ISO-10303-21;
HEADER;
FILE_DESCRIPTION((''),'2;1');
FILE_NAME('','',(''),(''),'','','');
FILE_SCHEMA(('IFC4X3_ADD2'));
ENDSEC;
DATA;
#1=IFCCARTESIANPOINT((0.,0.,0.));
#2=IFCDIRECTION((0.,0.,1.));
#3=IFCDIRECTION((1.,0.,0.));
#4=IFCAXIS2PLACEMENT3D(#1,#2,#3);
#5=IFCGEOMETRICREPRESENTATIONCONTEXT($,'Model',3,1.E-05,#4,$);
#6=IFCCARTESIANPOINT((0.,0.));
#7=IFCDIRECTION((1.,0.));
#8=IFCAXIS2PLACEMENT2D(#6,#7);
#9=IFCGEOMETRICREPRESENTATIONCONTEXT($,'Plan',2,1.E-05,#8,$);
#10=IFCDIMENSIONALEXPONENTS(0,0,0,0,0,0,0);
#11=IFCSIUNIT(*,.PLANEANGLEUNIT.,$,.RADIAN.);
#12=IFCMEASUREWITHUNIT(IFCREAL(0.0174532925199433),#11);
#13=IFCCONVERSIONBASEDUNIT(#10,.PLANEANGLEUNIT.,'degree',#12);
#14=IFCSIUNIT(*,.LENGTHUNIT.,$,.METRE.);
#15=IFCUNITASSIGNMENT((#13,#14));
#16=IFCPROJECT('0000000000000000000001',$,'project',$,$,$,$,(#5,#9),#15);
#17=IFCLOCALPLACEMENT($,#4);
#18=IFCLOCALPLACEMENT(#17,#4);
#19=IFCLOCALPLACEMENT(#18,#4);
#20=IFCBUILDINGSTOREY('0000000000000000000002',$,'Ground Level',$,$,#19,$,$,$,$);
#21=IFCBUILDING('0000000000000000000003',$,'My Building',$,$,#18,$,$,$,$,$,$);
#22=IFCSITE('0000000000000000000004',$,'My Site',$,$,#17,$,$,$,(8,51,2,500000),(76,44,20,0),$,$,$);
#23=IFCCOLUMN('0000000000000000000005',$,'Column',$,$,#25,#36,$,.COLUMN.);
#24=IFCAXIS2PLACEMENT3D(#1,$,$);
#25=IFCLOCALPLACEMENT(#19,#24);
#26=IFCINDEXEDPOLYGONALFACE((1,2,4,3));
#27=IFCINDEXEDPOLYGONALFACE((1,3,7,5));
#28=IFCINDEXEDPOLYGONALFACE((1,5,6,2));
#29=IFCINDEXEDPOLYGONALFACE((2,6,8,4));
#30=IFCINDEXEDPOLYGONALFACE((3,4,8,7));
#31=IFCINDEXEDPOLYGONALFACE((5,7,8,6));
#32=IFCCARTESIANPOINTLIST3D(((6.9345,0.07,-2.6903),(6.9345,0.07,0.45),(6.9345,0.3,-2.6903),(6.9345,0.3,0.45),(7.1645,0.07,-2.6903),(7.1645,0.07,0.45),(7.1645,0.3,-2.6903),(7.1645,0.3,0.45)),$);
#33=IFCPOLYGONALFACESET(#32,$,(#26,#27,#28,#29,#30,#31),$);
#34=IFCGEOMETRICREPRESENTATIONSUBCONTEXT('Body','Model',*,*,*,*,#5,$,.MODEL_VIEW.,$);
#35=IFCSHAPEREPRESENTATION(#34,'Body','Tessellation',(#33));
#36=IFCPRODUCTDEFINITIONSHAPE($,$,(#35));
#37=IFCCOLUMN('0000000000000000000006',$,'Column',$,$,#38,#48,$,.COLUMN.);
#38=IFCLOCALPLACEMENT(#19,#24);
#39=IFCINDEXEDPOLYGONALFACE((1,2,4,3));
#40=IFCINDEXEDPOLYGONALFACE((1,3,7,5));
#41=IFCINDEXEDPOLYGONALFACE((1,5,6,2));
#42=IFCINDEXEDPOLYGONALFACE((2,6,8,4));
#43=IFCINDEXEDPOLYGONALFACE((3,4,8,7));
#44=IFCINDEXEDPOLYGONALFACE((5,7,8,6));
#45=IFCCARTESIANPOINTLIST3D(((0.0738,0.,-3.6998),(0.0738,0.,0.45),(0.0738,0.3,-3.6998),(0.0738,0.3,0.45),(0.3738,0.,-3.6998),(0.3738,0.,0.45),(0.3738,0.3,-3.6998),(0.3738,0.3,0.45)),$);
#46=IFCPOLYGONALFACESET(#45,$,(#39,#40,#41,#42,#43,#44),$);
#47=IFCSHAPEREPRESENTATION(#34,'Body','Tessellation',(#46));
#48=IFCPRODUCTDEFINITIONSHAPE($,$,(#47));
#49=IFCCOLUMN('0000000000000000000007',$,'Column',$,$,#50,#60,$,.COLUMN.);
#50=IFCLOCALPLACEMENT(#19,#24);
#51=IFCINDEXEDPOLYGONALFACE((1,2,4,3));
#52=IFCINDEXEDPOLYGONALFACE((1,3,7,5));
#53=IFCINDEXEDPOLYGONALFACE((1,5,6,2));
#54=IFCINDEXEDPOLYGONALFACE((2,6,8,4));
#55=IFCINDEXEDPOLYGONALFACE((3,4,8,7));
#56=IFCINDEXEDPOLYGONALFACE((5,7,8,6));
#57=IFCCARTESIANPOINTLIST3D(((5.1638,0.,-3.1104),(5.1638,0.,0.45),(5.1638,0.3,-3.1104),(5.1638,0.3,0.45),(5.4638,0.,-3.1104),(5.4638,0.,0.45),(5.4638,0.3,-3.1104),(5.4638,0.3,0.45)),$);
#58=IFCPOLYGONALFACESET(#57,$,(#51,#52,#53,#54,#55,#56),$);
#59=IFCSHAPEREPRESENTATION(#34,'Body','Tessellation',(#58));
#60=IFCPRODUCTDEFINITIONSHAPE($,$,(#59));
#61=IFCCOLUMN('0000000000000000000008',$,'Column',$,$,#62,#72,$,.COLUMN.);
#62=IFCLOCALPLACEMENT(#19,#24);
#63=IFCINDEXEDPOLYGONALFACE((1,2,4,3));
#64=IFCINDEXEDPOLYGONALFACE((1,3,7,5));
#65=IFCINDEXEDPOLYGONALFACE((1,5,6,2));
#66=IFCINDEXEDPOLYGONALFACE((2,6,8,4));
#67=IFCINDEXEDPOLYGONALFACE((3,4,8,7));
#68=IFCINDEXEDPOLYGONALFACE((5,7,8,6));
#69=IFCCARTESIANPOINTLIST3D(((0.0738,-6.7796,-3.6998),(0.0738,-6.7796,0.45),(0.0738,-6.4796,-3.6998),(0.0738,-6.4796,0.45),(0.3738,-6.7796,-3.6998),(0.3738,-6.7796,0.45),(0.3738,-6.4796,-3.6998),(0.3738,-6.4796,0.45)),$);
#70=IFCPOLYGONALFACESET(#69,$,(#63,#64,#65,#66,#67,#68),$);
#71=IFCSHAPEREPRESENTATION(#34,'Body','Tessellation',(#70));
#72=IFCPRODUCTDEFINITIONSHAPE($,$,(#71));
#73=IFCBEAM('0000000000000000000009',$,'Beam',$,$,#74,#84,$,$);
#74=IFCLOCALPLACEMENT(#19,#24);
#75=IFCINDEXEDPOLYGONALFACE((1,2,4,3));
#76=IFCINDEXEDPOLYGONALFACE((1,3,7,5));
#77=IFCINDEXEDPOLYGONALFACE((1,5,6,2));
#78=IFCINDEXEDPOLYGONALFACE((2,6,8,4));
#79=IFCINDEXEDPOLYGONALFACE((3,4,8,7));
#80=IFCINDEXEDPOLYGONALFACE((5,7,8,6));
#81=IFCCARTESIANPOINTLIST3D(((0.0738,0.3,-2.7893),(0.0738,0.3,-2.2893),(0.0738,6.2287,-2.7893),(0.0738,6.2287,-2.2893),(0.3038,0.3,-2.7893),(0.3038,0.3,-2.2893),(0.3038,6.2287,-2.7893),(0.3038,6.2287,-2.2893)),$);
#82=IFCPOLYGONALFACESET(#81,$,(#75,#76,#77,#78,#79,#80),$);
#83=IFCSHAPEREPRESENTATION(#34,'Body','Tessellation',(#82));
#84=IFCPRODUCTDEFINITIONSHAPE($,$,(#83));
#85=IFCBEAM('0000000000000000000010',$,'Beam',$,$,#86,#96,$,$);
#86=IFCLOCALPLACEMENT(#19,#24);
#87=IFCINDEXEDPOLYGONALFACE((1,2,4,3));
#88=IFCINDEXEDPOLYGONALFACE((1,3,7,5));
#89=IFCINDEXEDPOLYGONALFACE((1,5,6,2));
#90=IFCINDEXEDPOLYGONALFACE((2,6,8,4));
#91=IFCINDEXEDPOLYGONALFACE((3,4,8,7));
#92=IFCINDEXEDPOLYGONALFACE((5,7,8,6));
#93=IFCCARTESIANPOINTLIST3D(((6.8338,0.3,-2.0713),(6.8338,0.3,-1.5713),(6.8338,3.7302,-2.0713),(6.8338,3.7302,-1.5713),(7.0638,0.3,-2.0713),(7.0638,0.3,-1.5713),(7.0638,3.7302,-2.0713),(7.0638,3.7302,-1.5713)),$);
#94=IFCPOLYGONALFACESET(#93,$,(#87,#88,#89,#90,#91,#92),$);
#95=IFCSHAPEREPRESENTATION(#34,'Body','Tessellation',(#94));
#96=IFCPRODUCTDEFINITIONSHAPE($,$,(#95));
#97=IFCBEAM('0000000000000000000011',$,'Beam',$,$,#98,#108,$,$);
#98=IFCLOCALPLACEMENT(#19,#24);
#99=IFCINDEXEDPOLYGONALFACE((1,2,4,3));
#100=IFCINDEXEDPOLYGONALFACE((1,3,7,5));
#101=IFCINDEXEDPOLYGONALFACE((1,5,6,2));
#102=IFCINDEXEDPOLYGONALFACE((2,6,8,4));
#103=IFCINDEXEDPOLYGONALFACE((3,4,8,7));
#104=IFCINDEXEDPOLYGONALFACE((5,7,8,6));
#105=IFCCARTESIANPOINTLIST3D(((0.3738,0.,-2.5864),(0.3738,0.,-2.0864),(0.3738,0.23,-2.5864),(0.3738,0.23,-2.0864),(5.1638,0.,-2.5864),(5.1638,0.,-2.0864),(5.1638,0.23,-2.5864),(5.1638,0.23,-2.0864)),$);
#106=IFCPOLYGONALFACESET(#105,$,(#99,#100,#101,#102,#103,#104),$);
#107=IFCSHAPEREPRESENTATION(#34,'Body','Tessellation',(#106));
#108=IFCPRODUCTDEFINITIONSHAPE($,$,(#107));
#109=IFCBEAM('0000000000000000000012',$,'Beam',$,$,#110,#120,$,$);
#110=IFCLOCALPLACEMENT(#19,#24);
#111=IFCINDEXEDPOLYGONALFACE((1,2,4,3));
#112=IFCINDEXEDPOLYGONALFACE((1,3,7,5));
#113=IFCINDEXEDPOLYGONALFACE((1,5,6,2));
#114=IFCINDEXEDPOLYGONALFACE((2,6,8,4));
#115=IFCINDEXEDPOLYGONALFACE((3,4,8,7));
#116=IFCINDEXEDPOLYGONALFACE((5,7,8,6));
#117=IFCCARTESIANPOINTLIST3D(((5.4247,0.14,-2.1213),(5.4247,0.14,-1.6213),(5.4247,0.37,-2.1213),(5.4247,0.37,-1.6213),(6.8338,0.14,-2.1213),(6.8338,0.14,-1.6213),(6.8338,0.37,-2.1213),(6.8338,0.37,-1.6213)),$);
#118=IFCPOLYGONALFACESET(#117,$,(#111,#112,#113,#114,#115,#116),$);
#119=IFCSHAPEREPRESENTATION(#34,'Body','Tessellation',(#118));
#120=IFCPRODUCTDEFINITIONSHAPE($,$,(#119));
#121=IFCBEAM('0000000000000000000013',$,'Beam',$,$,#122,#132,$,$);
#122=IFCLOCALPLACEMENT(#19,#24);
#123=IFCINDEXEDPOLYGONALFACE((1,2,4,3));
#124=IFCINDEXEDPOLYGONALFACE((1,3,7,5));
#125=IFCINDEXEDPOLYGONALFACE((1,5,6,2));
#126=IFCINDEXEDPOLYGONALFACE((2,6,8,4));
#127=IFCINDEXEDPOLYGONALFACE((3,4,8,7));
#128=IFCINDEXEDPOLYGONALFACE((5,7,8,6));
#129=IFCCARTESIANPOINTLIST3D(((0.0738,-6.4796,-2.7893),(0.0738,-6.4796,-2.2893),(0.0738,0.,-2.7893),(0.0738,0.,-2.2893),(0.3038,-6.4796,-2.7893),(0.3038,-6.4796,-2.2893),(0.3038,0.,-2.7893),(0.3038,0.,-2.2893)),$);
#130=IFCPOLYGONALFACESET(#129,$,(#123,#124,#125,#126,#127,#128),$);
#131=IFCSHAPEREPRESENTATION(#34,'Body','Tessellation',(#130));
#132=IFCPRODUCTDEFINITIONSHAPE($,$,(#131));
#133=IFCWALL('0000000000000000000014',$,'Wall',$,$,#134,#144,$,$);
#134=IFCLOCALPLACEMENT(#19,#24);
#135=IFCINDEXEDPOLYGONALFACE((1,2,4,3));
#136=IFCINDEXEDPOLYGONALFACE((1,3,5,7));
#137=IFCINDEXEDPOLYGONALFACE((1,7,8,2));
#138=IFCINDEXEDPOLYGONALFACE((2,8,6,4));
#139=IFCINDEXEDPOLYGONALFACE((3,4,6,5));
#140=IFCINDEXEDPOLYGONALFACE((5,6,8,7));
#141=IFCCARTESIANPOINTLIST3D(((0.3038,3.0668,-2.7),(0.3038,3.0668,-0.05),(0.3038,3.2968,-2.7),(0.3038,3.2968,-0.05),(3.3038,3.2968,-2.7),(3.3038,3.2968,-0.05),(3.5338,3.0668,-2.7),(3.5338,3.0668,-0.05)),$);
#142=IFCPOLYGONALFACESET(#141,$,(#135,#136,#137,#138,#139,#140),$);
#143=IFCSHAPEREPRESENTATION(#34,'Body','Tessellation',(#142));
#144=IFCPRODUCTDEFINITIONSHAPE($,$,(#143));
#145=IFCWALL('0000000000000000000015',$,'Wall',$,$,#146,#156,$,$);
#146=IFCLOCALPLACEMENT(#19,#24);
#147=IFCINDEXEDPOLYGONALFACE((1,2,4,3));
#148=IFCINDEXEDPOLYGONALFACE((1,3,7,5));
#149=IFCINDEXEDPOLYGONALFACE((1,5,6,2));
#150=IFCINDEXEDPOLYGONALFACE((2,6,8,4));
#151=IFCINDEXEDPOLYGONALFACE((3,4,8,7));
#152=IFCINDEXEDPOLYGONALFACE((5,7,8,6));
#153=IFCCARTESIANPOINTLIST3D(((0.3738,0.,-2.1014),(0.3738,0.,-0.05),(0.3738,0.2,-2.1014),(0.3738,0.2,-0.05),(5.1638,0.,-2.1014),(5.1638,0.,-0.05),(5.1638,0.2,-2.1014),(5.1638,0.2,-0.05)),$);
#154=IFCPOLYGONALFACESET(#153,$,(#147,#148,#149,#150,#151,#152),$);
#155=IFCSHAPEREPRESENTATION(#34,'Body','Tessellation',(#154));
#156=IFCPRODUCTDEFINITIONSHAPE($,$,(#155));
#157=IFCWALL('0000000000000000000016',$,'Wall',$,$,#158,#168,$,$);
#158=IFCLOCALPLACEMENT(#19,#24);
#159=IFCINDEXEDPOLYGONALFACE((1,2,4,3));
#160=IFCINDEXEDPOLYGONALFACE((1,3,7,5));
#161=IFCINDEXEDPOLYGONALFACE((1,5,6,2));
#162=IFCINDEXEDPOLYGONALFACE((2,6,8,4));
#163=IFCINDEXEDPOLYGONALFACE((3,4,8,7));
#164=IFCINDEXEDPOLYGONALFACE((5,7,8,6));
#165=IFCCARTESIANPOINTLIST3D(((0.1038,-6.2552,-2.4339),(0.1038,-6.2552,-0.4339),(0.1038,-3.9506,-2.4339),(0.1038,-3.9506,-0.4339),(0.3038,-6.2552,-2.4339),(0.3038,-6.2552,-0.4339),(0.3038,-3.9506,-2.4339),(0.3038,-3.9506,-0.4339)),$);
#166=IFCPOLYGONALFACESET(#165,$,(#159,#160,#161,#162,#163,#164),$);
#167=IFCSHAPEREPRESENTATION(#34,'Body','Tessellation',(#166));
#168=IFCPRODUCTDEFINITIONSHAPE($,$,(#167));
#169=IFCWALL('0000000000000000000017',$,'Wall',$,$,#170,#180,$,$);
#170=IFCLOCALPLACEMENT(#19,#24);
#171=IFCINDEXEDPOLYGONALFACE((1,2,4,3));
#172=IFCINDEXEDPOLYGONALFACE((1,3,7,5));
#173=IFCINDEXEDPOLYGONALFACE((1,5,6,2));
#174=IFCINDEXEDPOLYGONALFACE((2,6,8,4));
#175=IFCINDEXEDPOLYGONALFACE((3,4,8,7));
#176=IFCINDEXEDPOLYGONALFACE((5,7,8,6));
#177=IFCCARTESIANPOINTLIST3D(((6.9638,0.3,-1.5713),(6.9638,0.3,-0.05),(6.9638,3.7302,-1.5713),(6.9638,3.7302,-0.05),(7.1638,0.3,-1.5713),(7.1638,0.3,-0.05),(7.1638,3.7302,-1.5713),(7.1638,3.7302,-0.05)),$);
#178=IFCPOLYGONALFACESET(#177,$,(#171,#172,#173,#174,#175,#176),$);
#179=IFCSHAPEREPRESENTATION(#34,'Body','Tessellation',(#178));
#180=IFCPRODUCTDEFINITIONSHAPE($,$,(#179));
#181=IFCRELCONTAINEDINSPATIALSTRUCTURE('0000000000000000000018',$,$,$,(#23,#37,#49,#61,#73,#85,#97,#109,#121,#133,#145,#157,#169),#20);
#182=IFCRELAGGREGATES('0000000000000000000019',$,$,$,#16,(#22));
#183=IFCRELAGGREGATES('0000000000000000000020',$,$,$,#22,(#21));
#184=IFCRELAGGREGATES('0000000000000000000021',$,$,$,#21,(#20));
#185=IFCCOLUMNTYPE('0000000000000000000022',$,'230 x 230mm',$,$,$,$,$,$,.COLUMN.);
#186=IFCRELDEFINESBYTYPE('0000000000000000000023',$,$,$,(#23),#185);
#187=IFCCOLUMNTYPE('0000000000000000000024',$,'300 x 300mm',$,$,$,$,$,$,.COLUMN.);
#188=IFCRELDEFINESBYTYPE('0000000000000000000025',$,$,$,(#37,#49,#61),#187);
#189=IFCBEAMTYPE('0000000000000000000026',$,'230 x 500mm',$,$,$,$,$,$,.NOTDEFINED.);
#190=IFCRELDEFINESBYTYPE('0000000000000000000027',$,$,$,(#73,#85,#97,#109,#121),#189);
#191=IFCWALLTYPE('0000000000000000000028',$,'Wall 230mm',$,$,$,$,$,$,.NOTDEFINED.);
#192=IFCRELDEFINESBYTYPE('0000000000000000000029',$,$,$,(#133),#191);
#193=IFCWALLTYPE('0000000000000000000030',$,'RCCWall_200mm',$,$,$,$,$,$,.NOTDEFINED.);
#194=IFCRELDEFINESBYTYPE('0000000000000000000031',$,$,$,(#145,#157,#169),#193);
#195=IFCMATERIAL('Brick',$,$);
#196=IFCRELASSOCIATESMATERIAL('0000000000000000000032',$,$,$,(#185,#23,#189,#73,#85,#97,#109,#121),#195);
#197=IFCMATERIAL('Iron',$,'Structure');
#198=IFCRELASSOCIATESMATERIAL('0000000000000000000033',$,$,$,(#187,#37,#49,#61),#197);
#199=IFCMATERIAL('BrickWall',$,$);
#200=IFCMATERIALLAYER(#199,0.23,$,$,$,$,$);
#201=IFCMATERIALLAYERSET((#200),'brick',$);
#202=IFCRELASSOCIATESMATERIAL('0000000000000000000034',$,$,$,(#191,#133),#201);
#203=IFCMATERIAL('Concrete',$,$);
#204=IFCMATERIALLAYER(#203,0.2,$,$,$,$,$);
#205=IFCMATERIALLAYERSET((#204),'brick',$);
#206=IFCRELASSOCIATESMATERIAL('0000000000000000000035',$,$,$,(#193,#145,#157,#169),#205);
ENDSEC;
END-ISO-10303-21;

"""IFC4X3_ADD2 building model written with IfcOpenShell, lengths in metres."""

from ifc_helpers import new_model, entity, si_unit, converted_unit, frame, origin_with_axes, origin_2d_with_axis, place, context, subcontext, project, spatial, line, indexed_curve, rectangle, outline, extrude, material, layer, layer_set, layer_usage, material_profile, profile_set, profile_usage, type_object, element, save


model = new_model("IFC4X3_ADD2")

# Units and contexts
model_context = context("Model", 3, precision=1e-05, world=origin_with_axes())
plan_context = context("Plan", 2, precision=1e-05, world=origin_2d_with_axis())
body_context = subcontext(model_context, "Body", "Model", "MODEL_VIEW")
ifc_project = project(units=[converted_unit("PLANEANGLEUNIT", "degree", entity("IfcReal", 0.0174532925199433), si_unit("PLANEANGLEUNIT", "RADIAN"), dimensions=[0, 0, 0, 0, 0, 0, 0]), si_unit("LENGTHUNIT", "METRE")], contexts=[model_context, plan_context])

# Site, building, storey
site_placement = place(None, origin_with_axes())
site = spatial("IfcSite", under=ifc_project, at=site_placement, Name="My Site", RefLatitude=(8, 51, 2, 500000), RefLongitude=(76, 44, 20, 0))
building_placement = place(site_placement, origin_with_axes())
building = spatial("IfcBuilding", under=site, at=building_placement, Name="My Building")
storey_placement = place(building_placement, origin_with_axes())
storey = spatial("IfcBuildingStorey", under=building, at=storey_placement, Name="Ground Level")

# Columns
ifc_material_1 = material(Name="Brick")
ifc_material_profile_1 = material_profile(ifc_material_1, outline(indexed_curve([(-0.115, 0.115), (0.115, 0.115), (0.115, -0.115), (-0.115, -0.115), (-0.115, 0.115)])))
ifc_profile_set_1 = profile_set([ifc_material_profile_1])
ifc_profile_usage_1 = profile_usage(ifc_profile_set_1)
column_type_1 = type_object("IfcColumnType", Name="230 x 230mm", PredefinedType="COLUMN", material=ifc_profile_set_1)
column_1_placement = place(storey_placement, frame((7.0495, 0.185, -2.6903), z_axis=(0.0, 0.0, 1.0), x_axis=(1.0, 0.0, 0.0)))
element("IfcColumn", 1, at=column_1_placement, inside=storey, type_object=column_type_1, material=ifc_profile_usage_1, Name="Column", PredefinedType="COLUMN", context=body_context, shape_type="SweptSolid", body=[
    extrude(outline(indexed_curve([(-0.115, 0.115), (0.115, 0.115), (0.115, -0.115), (-0.115, -0.115), (-0.115, 0.115)])), origin_with_axes(), (0.0, 0.0, 1.0), 3.1403),
])
ifc_material_2 = material(Name="Iron", Category="Structure")
ifc_material_profile_2 = material_profile(ifc_material_2, outline(indexed_curve([(-0.15, 0.15), (0.15, 0.15), (0.15, -0.15), (-0.15, -0.15), (-0.15, 0.15)])))
ifc_profile_set_2 = profile_set([ifc_material_profile_2])
ifc_profile_usage_2 = profile_usage(ifc_profile_set_2)
column_type_2 = type_object("IfcColumnType", Name="300 x 300mm", PredefinedType="COLUMN", material=ifc_profile_set_2)
column_2_placement = place(storey_placement, frame((0.2238, 0.15, -3.6998), z_axis=(0.0, 0.0, 1.0), x_axis=(1.0, 0.0, 0.0)))
element("IfcColumn", 2, at=column_2_placement, inside=storey, type_object=column_type_2, material=ifc_profile_usage_2, Name="Column", PredefinedType="COLUMN", context=body_context, shape_type="SweptSolid", body=[
    extrude(outline(indexed_curve([(-0.15, 0.15), (0.15, 0.15), (0.15, -0.15), (-0.15, -0.15), (-0.15, 0.15)])), origin_with_axes(), (0.0, 0.0, 1.0), 4.1498),
])
ifc_profile_usage_3 = profile_usage(ifc_profile_set_2)
column_3_placement = place(storey_placement, frame((5.3138, 0.15, -3.1104), z_axis=(0.0, 0.0, 1.0), x_axis=(1.0, 0.0, 0.0)))
element("IfcColumn", 3, at=column_3_placement, inside=storey, type_object=column_type_2, material=ifc_profile_usage_3, Name="Column", PredefinedType="COLUMN", context=body_context, shape_type="SweptSolid", body=[
    extrude(outline(indexed_curve([(-0.15, 0.15), (0.15, 0.15), (0.15, -0.15), (-0.15, -0.15), (-0.15, 0.15)])), origin_with_axes(), (0.0, 0.0, 1.0), 3.5604),
])
ifc_profile_usage_4 = profile_usage(ifc_profile_set_2)
column_4_placement = place(storey_placement, frame((0.2238, -6.6296, -3.6998), z_axis=(0.0, 0.0, 1.0), x_axis=(1.0, 0.0, 0.0)))
element("IfcColumn", 4, at=column_4_placement, inside=storey, type_object=column_type_2, material=ifc_profile_usage_4, Name="Column", PredefinedType="COLUMN", context=body_context, shape_type="SweptSolid", body=[
    extrude(outline(indexed_curve([(-0.15, 0.15), (0.15, 0.15), (0.15, -0.15), (-0.15, -0.15), (-0.15, 0.15)])), origin_with_axes(), (0.0, 0.0, 1.0), 4.1498),
])

# Beams
ifc_material_profile_3 = material_profile(ifc_material_1, rectangle(XDim=0.23, YDim=0.5))
ifc_profile_set_3 = profile_set([ifc_material_profile_3], Name="rcc")
ifc_profile_usage_5 = profile_usage(ifc_profile_set_3)
beam_type = type_object("IfcBeamType", Name="230 x 500mm", PredefinedType="NOTDEFINED", material=ifc_profile_set_3)
beam_1_placement = place(storey_placement, frame((0.1888, 0.3, -2.5393), z_axis=(0.0, 1.0, 0.0), x_axis=(-1.0, 0.0, 0.0)))
element("IfcBeam", 5, at=beam_1_placement, inside=storey, type_object=beam_type, material=ifc_profile_usage_5, Name="Beam", context=body_context, shape_type="SweptSolid", body=[
    extrude(rectangle(XDim=0.23, YDim=0.5), origin_with_axes(), (0.0, 0.0, 1.0), 5.9287),
])
ifc_profile_usage_6 = profile_usage(ifc_profile_set_3)
beam_2_placement = place(storey_placement, frame((6.9488, 3.7302, -1.8213), z_axis=(0.0, -1.0, 0.0), x_axis=(1.0, 0.0, 0.0)))
element("IfcBeam", 6, at=beam_2_placement, inside=storey, type_object=beam_type, material=ifc_profile_usage_6, Name="Beam", context=body_context, shape_type="SweptSolid", body=[
    extrude(rectangle(XDim=0.23, YDim=0.5), origin_with_axes(), (0.0, 0.0, 1.0), 3.4302),
])
ifc_profile_usage_7 = profile_usage(ifc_profile_set_3)
beam_3_placement = place(storey_placement, frame((5.1638, 0.115, -2.3364), z_axis=(-1.0, 0.0, 0.0), x_axis=(0.0, -1.0, 0.0)))
element("IfcBeam", 7, at=beam_3_placement, inside=storey, type_object=beam_type, material=ifc_profile_usage_7, Name="Beam", context=body_context, shape_type="SweptSolid", body=[
    extrude(rectangle(XDim=0.23, YDim=0.5), origin_with_axes(), (0.0, 0.0, 1.0), 4.79),
])
ifc_profile_usage_8 = profile_usage(ifc_profile_set_3)
beam_4_placement = place(storey_placement, frame((6.8338, 0.255, -1.8713), z_axis=(-1.0, 0.0, 0.0), x_axis=(0.0, -1.0, 0.0)))
element("IfcBeam", 8, at=beam_4_placement, inside=storey, type_object=beam_type, material=ifc_profile_usage_8, Name="Beam", context=body_context, shape_type="SweptSolid", body=[
    extrude(rectangle(XDim=0.23, YDim=0.5), origin_with_axes(), (0.0, 0.0, 1.0), 1.4091),
])
ifc_profile_usage_9 = profile_usage(ifc_profile_set_3)
beam_5_placement = place(storey_placement, frame((0.1888, -6.4796, -2.5393), z_axis=(0.0, 1.0, 0.0), x_axis=(-1.0, 0.0, 0.0)))
element("IfcBeam", 9, at=beam_5_placement, inside=storey, type_object=beam_type, material=ifc_profile_usage_9, Name="Beam", context=body_context, shape_type="SweptSolid", body=[
    extrude(rectangle(XDim=0.23, YDim=0.5), origin_with_axes(), (0.0, 0.0, 1.0), 6.4796),
])

# Shared definitions
ifc_material_3 = material(Name="BrickWall")

# Walls
ifc_layer_1 = layer(ifc_material_3, 0.23)
ifc_layer_set_1 = layer_set([ifc_layer_1], Name="brick")
ifc_layer_usage_1 = layer_usage(ifc_layer_set_1, "AXIS2", "POSITIVE", 0.0)
wall_type_1 = type_object("IfcWallType", Name="Wall 230mm", PredefinedType="NOTDEFINED", material=ifc_layer_set_1)
wall_1_placement = place(storey_placement, frame((3.3038, 3.2968, -2.7), z_axis=(0.0, 0.0, 1.0), x_axis=(-1.0, 0.0, 0.0)))
element("IfcWall", 10, at=wall_1_placement, inside=storey, type_object=wall_type_1, material=ifc_layer_usage_1, Name="Wall", context=body_context, shape_type="SweptSolid", body=[
    extrude(outline(indexed_curve([(0.0, 0.0), (-0.23, 0.23), (3.0, 0.23), (3.0, 0.0)], segments=[line(1, 2, 3, 4, 1)])), origin_with_axes(), (0.0, 0.0, 1.0), 2.65),
])
ifc_material_4 = material(Name="Concrete")
ifc_layer_2 = layer(ifc_material_4, 0.2)
ifc_layer_set_2 = layer_set([ifc_layer_2], Name="brick")
ifc_layer_usage_2 = layer_usage(ifc_layer_set_2, "AXIS2", "POSITIVE", 0.0)
wall_type_2 = type_object("IfcWallType", Name="RCCWall_200mm", PredefinedType="NOTDEFINED", material=ifc_layer_set_2)
wall_2_placement = place(storey_placement, frame((0.3738, 0.0, -2.1014), z_axis=(0.0, 0.0, 1.0), x_axis=(1.0, -0.000001, 0.0)))
element("IfcWall", 11, at=wall_2_placement, inside=storey, type_object=wall_type_2, material=ifc_layer_usage_2, Name="Wall", context=body_context, shape_type="SweptSolid", body=[
    extrude(outline(indexed_curve([(0.0, 0.0), (0.0, 0.2), (4.79, 0.2), (4.79, 0.0)], segments=[line(1, 2, 3, 4, 1)])), origin_with_axes(), (0.0, 0.0, 1.0), 2.0514),
])
ifc_layer_usage_3 = layer_usage(ifc_layer_set_2, "AXIS2", "POSITIVE", 0.0)
wall_3_placement = place(storey_placement, frame((0.3038, -6.2552, -2.4339), z_axis=(0.0, 0.0, 1.0), x_axis=(0.0, 1.0, 0.0)))
element("IfcWall", 12, at=wall_3_placement, inside=storey, type_object=wall_type_2, material=ifc_layer_usage_3, Name="Wall", context=body_context, shape_type="SweptSolid", body=[
    extrude(outline(indexed_curve([(0.0, 0.0), (0.0, 0.2), (2.3046, 0.2), (2.3046, 0.0)], segments=[line(1, 2, 3, 4, 1)])), origin_with_axes(), (0.0, 0.0, 1.0), 2.0),
])
ifc_layer_usage_4 = layer_usage(ifc_layer_set_2, "AXIS2", "POSITIVE", 0.0)
wall_4_placement = place(storey_placement, frame((7.1638, 0.3, -1.5713), z_axis=(0.0, 0.0, 1.0), x_axis=(0.000001, 1.0, 0.0)))
element("IfcWall", 13, at=wall_4_placement, inside=storey, type_object=wall_type_2, material=ifc_layer_usage_4, Name="Wall", context=body_context, shape_type="SweptSolid", body=[
    extrude(outline(indexed_curve([(0.0, 0.0), (0.0, 0.2), (3.4302, 0.2), (3.4302, 0.0)], segments=[line(1, 2, 3, 4, 1)])), origin_with_axes(), (0.0, 0.0, 1.0), 1.5213),
])

save(model, "model.ifc")
